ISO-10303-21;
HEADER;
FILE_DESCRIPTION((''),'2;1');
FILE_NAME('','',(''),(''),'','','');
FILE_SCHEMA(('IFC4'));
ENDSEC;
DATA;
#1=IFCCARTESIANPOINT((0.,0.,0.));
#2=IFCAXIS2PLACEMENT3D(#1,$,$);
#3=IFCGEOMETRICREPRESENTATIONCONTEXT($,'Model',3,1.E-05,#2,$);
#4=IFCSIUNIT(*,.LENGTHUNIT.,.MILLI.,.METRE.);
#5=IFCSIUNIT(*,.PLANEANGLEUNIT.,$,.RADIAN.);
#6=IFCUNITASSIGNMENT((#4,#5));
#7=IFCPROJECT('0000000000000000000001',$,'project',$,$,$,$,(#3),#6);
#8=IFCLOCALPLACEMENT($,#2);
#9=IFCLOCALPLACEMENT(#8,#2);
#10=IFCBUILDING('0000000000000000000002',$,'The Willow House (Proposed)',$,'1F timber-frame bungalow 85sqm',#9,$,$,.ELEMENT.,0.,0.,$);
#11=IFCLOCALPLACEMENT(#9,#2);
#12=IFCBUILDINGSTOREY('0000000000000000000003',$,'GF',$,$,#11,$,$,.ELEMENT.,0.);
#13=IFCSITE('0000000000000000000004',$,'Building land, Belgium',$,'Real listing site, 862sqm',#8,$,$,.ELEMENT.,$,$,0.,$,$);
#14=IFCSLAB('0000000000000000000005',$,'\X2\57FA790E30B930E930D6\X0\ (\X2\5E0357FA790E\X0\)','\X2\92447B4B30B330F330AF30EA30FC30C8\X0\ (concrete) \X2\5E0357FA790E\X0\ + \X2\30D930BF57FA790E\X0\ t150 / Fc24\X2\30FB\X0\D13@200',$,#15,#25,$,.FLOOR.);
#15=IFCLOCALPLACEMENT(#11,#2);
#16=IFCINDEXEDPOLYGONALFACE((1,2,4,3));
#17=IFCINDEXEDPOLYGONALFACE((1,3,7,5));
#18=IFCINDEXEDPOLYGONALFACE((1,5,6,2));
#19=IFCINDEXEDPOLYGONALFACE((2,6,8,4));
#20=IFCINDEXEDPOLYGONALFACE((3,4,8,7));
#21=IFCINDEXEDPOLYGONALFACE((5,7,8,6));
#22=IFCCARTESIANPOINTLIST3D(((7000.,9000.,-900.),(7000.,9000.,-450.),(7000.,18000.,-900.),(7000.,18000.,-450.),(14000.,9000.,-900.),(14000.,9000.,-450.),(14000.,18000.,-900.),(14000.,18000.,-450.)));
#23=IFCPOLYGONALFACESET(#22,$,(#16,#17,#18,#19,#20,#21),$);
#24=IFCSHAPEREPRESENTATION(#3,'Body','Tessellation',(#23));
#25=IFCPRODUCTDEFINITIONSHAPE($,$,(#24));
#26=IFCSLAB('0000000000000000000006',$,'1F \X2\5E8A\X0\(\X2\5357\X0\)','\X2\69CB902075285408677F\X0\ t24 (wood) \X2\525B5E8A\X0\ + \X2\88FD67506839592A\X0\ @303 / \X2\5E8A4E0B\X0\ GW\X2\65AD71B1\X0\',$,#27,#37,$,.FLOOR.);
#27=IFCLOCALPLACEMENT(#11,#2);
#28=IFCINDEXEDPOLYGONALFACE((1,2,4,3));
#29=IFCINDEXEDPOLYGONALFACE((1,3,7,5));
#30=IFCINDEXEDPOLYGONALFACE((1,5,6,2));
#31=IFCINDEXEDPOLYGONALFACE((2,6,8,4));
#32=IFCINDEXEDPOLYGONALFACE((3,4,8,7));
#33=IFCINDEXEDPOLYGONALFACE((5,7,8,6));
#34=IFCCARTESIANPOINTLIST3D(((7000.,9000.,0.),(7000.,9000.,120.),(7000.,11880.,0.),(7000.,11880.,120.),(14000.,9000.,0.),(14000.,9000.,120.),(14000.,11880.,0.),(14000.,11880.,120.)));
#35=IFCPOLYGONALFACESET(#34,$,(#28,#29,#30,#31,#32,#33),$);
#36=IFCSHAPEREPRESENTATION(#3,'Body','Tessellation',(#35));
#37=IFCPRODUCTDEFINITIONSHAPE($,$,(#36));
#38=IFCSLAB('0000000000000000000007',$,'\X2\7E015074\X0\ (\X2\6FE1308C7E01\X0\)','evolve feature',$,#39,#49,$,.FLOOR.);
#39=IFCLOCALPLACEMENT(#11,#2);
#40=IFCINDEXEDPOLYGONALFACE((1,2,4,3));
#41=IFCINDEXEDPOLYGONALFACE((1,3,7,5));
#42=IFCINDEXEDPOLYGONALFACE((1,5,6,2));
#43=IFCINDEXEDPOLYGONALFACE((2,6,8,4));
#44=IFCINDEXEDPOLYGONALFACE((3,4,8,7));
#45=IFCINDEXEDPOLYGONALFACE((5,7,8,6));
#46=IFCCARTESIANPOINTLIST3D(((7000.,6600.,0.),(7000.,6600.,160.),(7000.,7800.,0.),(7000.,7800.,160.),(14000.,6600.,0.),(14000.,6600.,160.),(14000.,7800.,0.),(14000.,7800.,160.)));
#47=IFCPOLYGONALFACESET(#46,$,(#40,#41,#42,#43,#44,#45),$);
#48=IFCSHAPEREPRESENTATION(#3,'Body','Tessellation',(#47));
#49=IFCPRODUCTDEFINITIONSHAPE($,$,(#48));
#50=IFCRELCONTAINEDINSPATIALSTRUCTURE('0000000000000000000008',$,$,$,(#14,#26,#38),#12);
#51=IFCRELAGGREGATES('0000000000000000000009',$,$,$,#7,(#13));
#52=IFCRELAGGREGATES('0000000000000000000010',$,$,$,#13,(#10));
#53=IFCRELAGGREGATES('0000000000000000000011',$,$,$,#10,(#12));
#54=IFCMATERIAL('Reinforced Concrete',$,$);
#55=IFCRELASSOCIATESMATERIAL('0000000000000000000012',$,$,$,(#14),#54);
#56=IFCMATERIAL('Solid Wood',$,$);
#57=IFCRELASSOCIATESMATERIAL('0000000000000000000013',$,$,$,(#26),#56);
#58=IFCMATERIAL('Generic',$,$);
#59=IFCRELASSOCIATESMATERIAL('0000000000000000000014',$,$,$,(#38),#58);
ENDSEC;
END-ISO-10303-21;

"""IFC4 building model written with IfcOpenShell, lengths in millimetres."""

from ifc_helpers import new_model, si_unit, frame, frame_2d, origin, place, context, project, spatial, rectangle, extrude, material, element, save


model = new_model("IFC4")

# Units and contexts
model_context = context("Model", 3, precision=1e-05, world=origin())
ifc_project = project(units=[si_unit("LENGTHUNIT", "METRE", prefix="MILLI"), si_unit("PLANEANGLEUNIT", "RADIAN")], contexts=[model_context])

# Site, building, storey
site_placement = place(None, origin())
site = spatial("IfcSite", under=ifc_project, at=site_placement, Name="Building land, Belgium", ObjectType="Real listing site, 862sqm", CompositionType="ELEMENT", RefElevation=0.0)
building_placement = place(site_placement, origin())
building = spatial("IfcBuilding", under=site, at=building_placement, Name="The Willow House (Proposed)", ObjectType="1F timber-frame bungalow 85sqm", CompositionType="ELEMENT", ElevationOfRefHeight=0.0, ElevationOfTerrain=0.0)
storey_placement = place(building_placement, origin())
storey = spatial("IfcBuildingStorey", under=building, at=storey_placement, Name="GF", CompositionType="ELEMENT", Elevation=0.0)

# Slabs
ifc_material_1 = material(Name="Reinforced Concrete")
slab_1_placement = place(storey_placement, frame((3500.0, 4500.0, -450.0)))
element("IfcSlab", 1, at=slab_1_placement, inside=storey, material=ifc_material_1, Name="基礎スラブ (布基礎)", Description="鉄筋コンクリート (concrete) 布基礎 + ベタ基礎 t150 / Fc24・D13@200", PredefinedType="FLOOR", context=model_context, shape_type="SweptSolid", body=[
    extrude(rectangle(XDim=7000.0, YDim=9000.0, at=frame_2d((3500.0, 4500.0))), frame((3500.0, 4500.0, -450.0)), (0.0, 0.0, 1.0), 450.0),
])
ifc_material_2 = material(Name="Solid Wood")
slab_2_placement = place(storey_placement, frame((3500.0, 4500.0, 0.0)))
element("IfcSlab", 2, at=slab_2_placement, inside=storey, material=ifc_material_2, Name="1F 床(南)", Description="構造用合板 t24 (wood) 剛床 + 製材根太 @303 / 床下 GW断熱", PredefinedType="FLOOR", context=model_context, shape_type="SweptSolid", body=[
    extrude(rectangle(XDim=7000.0, YDim=2880.0, at=frame_2d((3500.0, 1440.0))), frame((3500.0, 4500.0, 0.0)), (0.0, 0.0, 1.0), 120.0),
])
ifc_material_3 = material(Name="Generic")
slab_3_placement = place(storey_placement, frame((3500.0, 3300.0, 0.0)))
element("IfcSlab", 3, at=slab_3_placement, inside=storey, material=ifc_material_3, Name="縁側 (濡れ縁)", Description="evolve feature", PredefinedType="FLOOR", context=model_context, shape_type="SweptSolid", body=[
    extrude(rectangle(XDim=7000.0, YDim=1200.0, at=frame_2d((3500.0, 600.0))), frame((3500.0, 3300.0, 0.0)), (0.0, 0.0, 1.0), 160.0),
])

save(model, "model.ifc")
